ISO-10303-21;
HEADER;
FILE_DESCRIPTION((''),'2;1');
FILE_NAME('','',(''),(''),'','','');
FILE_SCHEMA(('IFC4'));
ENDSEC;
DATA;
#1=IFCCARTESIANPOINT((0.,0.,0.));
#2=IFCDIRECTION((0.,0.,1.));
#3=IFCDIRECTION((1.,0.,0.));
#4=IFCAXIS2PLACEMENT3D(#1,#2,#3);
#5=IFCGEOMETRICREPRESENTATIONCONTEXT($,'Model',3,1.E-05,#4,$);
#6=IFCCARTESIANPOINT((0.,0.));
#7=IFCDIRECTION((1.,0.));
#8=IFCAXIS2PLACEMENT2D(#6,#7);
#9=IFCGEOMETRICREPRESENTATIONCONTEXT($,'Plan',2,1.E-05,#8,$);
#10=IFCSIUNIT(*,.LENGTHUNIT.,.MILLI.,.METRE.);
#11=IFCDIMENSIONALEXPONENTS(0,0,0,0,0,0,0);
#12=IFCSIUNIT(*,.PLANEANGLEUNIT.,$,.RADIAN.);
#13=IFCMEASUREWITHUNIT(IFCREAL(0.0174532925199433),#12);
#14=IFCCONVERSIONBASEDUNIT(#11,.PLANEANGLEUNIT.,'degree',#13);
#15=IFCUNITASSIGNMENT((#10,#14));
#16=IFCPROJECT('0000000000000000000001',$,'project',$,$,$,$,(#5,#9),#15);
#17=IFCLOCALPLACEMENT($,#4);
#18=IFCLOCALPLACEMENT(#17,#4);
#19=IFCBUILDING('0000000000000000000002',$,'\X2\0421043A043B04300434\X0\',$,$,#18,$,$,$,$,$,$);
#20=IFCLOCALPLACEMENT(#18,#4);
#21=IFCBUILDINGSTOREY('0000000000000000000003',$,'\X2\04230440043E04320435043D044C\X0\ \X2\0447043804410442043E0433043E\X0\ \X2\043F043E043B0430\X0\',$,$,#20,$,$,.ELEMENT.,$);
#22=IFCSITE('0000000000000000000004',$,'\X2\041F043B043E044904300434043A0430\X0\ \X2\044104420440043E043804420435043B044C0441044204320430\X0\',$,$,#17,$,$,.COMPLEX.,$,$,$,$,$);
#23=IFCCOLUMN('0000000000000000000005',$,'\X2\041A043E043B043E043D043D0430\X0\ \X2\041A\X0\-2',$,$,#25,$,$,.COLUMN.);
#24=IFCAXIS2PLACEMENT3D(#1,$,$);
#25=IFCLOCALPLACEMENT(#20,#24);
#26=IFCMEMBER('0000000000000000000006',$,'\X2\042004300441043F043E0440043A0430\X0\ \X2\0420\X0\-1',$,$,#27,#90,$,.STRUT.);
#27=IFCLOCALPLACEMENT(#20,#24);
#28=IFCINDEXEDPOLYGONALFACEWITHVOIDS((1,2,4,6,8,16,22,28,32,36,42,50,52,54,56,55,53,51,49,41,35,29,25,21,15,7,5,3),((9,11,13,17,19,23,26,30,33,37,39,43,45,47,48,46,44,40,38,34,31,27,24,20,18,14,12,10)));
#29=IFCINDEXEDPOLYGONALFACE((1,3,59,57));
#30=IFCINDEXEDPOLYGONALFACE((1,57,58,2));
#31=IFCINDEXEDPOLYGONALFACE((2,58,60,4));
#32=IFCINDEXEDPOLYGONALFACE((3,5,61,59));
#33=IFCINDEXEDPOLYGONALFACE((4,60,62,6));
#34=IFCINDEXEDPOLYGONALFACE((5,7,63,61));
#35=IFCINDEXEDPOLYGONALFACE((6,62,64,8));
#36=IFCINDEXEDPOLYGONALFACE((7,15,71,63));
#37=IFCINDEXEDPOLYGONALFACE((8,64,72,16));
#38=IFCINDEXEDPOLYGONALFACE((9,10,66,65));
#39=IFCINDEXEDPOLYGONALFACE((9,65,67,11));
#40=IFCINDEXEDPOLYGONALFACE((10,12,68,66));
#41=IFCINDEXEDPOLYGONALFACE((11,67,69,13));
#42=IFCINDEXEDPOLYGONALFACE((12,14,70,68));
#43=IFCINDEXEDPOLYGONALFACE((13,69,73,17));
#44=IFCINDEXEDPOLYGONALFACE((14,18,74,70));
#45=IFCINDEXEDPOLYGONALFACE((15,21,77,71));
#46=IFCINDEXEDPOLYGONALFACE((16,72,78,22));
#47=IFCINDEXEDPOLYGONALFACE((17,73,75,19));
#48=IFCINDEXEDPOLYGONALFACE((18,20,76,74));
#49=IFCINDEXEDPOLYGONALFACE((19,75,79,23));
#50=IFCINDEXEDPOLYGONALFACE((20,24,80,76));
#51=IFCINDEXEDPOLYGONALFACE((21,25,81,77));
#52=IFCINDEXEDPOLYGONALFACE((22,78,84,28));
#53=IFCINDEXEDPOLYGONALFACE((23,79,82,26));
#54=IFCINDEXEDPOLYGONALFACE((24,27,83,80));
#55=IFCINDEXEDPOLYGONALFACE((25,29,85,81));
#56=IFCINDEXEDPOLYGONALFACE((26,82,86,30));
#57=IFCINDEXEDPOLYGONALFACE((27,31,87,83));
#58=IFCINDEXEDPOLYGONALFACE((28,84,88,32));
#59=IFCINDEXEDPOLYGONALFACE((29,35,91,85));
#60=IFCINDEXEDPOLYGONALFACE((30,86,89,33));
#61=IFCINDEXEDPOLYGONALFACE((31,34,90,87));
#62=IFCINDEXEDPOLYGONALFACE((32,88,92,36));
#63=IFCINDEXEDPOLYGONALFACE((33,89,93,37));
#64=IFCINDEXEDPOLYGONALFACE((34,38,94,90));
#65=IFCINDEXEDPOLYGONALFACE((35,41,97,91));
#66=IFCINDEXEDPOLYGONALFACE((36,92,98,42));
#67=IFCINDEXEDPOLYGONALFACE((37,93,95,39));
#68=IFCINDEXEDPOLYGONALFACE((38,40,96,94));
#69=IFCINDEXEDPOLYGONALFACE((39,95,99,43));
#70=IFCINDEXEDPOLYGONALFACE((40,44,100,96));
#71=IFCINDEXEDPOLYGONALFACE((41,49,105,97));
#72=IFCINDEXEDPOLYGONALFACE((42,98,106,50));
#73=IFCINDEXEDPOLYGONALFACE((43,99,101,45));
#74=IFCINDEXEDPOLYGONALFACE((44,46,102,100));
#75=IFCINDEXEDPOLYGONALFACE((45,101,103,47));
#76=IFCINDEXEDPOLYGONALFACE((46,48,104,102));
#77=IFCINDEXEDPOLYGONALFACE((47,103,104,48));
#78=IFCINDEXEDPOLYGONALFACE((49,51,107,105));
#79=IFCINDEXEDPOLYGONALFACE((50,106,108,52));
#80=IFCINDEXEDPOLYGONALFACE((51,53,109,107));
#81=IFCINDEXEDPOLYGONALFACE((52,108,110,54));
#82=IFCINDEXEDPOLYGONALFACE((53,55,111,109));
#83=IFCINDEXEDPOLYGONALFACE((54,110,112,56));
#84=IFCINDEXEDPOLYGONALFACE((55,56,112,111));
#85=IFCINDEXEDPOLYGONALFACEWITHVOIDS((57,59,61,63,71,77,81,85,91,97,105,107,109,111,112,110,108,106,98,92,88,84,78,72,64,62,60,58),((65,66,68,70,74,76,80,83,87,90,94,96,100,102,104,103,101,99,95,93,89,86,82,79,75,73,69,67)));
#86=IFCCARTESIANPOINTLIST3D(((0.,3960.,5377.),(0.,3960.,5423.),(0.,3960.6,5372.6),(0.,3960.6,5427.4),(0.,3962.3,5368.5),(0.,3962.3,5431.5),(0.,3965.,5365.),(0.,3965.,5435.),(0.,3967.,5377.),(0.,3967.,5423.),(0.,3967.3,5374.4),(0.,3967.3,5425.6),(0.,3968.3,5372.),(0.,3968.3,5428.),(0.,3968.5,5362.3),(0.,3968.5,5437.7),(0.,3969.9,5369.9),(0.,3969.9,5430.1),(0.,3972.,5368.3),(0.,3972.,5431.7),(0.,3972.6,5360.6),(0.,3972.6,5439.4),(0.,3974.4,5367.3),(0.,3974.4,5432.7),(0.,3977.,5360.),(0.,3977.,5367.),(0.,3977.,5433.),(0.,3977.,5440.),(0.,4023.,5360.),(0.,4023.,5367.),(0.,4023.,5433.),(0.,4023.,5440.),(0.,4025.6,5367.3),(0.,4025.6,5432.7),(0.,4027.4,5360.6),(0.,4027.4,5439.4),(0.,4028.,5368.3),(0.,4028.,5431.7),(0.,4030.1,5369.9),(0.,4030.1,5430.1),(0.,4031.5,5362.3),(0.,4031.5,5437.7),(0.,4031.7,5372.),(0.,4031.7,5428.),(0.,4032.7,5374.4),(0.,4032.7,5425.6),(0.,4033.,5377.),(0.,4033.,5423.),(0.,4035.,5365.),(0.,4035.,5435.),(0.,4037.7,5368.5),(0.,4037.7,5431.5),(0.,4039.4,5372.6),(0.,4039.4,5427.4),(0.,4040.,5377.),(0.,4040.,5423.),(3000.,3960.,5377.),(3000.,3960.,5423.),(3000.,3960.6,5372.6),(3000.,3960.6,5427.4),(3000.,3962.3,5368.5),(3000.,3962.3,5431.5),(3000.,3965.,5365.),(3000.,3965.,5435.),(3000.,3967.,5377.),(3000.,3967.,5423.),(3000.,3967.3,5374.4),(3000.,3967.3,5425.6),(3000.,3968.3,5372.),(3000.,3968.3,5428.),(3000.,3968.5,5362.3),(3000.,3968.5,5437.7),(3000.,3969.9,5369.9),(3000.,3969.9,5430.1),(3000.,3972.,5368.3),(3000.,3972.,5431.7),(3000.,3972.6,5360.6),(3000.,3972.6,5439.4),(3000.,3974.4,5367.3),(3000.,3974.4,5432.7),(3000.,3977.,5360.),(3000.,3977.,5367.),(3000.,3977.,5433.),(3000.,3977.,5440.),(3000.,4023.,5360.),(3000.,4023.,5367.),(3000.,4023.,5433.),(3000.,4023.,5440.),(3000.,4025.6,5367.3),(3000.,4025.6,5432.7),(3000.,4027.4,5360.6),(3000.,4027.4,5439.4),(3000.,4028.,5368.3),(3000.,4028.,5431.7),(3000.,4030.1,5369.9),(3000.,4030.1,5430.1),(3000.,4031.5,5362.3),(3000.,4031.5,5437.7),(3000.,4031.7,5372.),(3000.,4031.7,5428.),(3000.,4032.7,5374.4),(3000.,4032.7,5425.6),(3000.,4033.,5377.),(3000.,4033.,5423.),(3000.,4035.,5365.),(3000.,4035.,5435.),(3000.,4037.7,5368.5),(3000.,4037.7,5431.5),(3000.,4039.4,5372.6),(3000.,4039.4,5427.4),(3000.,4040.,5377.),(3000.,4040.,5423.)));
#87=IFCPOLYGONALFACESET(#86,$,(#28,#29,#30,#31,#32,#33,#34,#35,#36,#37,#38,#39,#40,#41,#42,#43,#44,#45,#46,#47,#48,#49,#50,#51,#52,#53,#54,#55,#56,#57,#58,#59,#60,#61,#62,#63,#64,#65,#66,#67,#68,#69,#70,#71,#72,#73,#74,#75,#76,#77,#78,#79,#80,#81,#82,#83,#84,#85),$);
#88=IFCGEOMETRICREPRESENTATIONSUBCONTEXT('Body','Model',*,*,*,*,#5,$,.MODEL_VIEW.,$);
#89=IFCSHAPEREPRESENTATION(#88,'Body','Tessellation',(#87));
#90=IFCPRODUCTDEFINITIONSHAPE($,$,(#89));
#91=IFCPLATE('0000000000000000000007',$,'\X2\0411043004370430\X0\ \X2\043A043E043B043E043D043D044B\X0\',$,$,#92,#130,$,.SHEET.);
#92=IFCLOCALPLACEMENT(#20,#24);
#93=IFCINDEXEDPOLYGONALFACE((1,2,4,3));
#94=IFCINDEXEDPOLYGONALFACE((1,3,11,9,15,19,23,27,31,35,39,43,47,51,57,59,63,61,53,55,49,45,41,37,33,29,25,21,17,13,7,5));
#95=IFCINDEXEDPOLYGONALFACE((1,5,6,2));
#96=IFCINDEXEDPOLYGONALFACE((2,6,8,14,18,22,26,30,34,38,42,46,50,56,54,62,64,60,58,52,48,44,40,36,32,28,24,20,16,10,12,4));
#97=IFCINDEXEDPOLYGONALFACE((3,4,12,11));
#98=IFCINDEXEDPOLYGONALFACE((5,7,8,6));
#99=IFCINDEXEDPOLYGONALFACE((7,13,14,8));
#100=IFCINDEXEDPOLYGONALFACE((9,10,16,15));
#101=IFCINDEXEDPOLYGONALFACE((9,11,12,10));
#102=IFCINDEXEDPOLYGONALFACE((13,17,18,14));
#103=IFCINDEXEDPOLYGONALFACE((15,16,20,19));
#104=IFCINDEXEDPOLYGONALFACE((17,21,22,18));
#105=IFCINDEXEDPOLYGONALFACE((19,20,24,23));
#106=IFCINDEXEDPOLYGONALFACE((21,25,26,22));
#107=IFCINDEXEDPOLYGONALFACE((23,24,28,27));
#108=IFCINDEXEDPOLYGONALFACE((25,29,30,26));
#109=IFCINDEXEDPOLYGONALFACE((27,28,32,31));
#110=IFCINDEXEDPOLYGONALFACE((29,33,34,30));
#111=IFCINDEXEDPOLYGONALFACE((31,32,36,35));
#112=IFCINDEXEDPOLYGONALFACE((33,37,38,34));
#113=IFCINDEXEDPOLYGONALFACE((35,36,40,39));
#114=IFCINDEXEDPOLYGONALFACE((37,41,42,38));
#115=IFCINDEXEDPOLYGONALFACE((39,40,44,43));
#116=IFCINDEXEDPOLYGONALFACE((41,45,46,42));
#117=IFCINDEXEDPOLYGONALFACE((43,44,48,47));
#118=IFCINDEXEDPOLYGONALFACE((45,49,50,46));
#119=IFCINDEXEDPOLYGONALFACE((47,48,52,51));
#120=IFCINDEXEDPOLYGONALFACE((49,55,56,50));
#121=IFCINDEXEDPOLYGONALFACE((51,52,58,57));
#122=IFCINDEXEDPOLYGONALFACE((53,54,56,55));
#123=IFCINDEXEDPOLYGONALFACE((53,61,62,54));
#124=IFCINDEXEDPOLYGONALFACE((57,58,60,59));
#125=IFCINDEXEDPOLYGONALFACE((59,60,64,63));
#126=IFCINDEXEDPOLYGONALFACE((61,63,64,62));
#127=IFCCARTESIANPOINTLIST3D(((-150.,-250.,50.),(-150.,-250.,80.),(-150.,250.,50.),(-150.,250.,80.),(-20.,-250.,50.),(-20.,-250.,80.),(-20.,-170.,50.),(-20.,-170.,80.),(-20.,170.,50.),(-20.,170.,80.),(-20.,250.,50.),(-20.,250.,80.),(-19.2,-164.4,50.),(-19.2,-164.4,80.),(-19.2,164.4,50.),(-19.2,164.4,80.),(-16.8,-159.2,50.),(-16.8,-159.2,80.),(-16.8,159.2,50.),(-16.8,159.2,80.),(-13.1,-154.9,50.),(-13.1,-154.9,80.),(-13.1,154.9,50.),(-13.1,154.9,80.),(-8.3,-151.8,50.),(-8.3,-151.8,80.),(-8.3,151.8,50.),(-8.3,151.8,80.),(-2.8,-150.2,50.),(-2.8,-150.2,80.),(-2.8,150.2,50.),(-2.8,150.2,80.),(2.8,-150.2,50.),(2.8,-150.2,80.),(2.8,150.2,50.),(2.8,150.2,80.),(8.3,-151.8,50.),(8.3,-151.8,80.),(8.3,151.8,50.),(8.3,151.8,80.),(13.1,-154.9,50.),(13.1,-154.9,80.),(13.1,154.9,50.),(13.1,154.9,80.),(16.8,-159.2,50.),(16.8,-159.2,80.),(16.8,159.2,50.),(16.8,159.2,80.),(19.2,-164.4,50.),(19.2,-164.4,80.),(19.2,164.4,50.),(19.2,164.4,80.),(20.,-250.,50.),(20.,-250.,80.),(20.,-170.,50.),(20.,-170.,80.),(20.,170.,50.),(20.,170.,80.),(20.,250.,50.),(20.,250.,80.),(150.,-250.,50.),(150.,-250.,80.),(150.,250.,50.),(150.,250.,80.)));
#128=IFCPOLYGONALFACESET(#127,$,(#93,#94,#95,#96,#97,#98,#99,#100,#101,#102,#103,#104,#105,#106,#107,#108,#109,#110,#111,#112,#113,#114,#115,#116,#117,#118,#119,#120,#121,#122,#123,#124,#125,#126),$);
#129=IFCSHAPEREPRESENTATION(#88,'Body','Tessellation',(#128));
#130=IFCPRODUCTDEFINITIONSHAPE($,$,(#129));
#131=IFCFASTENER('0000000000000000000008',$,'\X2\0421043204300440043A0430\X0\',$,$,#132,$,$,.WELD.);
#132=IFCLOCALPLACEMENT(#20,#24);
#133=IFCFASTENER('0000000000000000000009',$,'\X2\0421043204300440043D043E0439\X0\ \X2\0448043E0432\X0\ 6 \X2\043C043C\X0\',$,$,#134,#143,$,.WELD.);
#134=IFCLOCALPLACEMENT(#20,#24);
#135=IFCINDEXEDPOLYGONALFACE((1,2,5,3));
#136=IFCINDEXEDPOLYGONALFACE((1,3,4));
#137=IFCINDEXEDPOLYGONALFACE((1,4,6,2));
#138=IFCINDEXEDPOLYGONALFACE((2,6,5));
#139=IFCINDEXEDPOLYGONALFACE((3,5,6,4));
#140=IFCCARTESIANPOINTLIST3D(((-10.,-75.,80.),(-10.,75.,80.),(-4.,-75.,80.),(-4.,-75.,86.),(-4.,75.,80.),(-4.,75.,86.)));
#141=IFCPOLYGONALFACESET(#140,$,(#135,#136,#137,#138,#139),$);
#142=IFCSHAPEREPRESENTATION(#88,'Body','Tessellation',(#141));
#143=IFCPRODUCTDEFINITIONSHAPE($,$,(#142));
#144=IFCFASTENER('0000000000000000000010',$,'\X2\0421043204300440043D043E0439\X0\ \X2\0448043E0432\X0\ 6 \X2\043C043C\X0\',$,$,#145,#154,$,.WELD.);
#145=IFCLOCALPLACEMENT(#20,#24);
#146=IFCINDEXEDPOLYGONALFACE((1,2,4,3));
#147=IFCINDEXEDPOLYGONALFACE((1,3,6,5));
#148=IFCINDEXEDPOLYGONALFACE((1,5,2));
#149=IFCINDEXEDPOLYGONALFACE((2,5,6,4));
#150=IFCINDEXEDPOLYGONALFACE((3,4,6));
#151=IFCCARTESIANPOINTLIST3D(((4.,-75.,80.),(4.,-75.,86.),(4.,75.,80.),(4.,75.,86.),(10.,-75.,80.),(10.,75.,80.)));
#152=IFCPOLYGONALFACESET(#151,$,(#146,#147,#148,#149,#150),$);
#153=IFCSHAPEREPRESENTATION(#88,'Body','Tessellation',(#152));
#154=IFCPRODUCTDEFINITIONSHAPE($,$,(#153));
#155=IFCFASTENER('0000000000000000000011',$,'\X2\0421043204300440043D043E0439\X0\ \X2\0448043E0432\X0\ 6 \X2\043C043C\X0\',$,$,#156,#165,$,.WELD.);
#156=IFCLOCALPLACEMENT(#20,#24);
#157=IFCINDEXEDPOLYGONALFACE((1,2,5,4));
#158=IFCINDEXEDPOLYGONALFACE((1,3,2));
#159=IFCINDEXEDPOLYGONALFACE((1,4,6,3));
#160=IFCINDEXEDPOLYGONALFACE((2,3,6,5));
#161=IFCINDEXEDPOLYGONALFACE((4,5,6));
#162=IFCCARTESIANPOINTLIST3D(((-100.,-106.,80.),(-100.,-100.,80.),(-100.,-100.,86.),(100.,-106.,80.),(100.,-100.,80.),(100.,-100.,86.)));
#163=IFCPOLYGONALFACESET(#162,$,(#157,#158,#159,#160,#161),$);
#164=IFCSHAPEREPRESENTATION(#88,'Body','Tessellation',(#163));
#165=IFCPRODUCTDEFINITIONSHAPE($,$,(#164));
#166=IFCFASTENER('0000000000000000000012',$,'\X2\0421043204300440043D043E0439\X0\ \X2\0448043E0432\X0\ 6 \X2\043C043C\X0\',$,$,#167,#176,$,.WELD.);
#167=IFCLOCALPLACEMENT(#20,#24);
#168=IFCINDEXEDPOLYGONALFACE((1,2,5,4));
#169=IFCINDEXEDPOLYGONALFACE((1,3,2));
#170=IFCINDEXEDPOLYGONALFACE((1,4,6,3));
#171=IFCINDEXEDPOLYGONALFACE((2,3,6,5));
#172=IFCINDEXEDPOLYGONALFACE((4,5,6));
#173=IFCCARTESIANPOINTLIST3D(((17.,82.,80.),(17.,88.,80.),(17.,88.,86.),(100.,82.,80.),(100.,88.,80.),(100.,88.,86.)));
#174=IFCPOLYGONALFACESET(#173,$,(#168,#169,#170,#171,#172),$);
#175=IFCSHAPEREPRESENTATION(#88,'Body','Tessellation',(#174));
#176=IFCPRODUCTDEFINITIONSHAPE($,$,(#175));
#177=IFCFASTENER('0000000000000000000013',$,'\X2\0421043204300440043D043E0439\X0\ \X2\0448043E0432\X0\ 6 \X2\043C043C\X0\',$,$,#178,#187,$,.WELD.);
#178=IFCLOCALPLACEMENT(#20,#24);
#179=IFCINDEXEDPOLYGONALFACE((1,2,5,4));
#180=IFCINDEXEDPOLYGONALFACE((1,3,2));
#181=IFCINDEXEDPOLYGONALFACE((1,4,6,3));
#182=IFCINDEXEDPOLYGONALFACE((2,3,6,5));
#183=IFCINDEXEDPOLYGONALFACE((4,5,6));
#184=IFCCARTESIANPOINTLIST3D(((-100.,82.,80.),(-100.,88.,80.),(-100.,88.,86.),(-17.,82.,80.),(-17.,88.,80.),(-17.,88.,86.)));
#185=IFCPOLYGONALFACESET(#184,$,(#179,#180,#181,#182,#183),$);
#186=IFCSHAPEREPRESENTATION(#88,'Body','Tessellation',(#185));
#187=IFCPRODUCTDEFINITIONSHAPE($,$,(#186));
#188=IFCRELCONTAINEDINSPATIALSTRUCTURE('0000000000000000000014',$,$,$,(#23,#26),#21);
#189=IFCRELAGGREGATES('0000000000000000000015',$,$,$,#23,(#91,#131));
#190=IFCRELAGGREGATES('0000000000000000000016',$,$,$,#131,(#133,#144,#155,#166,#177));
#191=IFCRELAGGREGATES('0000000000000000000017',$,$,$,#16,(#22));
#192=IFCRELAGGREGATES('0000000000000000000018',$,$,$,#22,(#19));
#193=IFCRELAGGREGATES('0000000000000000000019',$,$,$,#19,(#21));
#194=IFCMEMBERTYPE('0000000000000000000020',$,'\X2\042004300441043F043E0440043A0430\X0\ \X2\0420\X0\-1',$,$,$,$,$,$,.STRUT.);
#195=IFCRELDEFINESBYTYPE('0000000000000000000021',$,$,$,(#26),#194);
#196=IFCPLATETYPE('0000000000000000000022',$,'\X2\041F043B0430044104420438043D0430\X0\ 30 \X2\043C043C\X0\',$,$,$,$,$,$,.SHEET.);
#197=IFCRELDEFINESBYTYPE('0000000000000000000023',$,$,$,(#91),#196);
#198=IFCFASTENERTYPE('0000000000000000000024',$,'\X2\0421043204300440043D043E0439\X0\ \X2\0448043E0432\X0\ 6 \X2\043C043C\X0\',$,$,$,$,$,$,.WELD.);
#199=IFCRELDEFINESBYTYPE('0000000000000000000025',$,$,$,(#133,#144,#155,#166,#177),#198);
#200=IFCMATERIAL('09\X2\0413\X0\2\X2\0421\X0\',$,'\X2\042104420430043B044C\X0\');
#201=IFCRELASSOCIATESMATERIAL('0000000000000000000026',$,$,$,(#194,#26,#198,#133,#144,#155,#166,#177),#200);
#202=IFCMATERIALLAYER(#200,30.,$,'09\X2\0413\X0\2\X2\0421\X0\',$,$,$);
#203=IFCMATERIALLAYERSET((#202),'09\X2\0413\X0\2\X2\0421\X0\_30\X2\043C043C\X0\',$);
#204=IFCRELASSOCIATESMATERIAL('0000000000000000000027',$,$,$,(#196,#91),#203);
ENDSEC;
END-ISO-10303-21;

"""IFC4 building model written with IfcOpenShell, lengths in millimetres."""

from ifc_helpers import new_model, entity, si_unit, converted_unit, frame, origin_with_axes, origin_2d_with_axis, place, context, subcontext, project, spatial, line, arc, indexed_curve, hollow_rectangle, outline, extrude, material, layer, layer_set, layer_usage, material_profile, profile_set, profile_usage, type_object, element, aggregate, save


model = new_model("IFC4")

# Units and contexts
model_context = context("Model", 3, precision=1e-05, world=origin_with_axes())
plan_context = context("Plan", 2, precision=1e-05, world=origin_2d_with_axis())
body_context = subcontext(model_context, "Body", "Model", "MODEL_VIEW")
ifc_project = project(units=[si_unit("LENGTHUNIT", "METRE", prefix="MILLI"), converted_unit("PLANEANGLEUNIT", "degree", entity("IfcReal", 0.0174532925199433), si_unit("PLANEANGLEUNIT", "RADIAN"), dimensions=[0, 0, 0, 0, 0, 0, 0])], contexts=[model_context, plan_context])

# Site, building, storey
site_placement = place(None, origin_with_axes())
site = spatial("IfcSite", under=ifc_project, at=site_placement, Name="Площадка строительства", CompositionType="COMPLEX")
building_placement = place(site_placement, origin_with_axes())
building = spatial("IfcBuilding", under=site, at=building_placement, Name="Склад")
storey_placement = place(building_placement, origin_with_axes())
storey = spatial("IfcBuildingStorey", under=building, at=storey_placement, Name="Уровень чистого пола", CompositionType="ELEMENT")

# Column
placement_1 = place(storey_placement, origin_with_axes())
column_1 = element("IfcColumn", 1, at=placement_1, inside=storey, Name="Колонна К-2", PredefinedType="COLUMN")
placement_2 = place(placement_1, origin_with_axes())

# Member
ifc_material_1 = material(Name="09Г2С", Category="Сталь")
ifc_material_profile_1 = material_profile(ifc_material_1, hollow_rectangle(XDim=80.0, YDim=80.0, WallThickness=7.0, InnerFilletRadius=10.0, OuterFilletRadius=17.0))
ifc_profile_set_1 = profile_set([ifc_material_profile_1], Name="PK80x7_09G2S")
ifc_profile_usage_1 = profile_usage(ifc_profile_set_1, cardinal=5)
member_type_1 = type_object("IfcMemberType", Name="Распорка Р-1", PredefinedType="STRUT", material=ifc_profile_set_1)
for number, where, z_axis, x_axis, name in (
    (2, (0.0, 4000.0, 5400.0), (1.0, 0.0, 0.0), (0.0, 1.0, 0.0), "Распорка Р-1"),
):
    element("IfcMember", number, at=place(storey_placement, frame(where, z_axis=z_axis, x_axis=x_axis)), inside=storey, type_object=member_type_1, material=ifc_profile_usage_1, Name=name, PredefinedType="STRUT", context=body_context, shape_type="SweptSolid", body=[
        extrude(hollow_rectangle(XDim=80.0, YDim=80.0, WallThickness=7.0, InnerFilletRadius=10.0, OuterFilletRadius=17.0), origin_with_axes(), (0.0, 0.0, 1.0), 3000.0),
    ])

# Plate
ifc_layer = layer(ifc_material_1, 30.0, Name="09Г2С")
ifc_layer_set = layer_set([ifc_layer], Name="09Г2С_30мм")
ifc_layer_usage = layer_usage(ifc_layer_set, "AXIS3", "POSITIVE", 0.0)
plate_type = type_object("IfcPlateType", Name="Пластина 30 мм", PredefinedType="SHEET", material=ifc_layer_set)
plate_placement = place(placement_1, frame((0.0, 0.0, 50.0), z_axis=(0.0, 0.0, 1.0), x_axis=(1.0, 0.0, 0.0)))
plate = element("IfcPlate", 3, at=plate_placement, type_object=plate_type, material=ifc_layer_usage, Name="База колонны", PredefinedType="SHEET", context=body_context, shape_type="SweptSolid", body=[
    extrude(outline(indexed_curve([(-20.0, -170.0), (0.0, -150.0), (20.0, -170.0), (20.0, -250.0), (150.0, -250.0), (150.0, 250.0), (20.0, 250.0), (20.0, 170.0), (0.0, 150.0), (-20.0, 170.0), (-20.0, 250.0), (-150.0, 250.0), (-150.0, -250.0), (-20.0, -250.0)], segments=[line(11, 12), line(12, 13), line(13, 14), line(14, 1), arc(1, 2, 3), line(3, 4), line(4, 5), line(5, 6), line(6, 7), line(7, 8), arc(8, 9, 10), line(10, 11)], self_intersect=False)), None, (0.0, 0.0, 1.0), 30.0),
])

# Fasteners
fastener_1 = element("IfcFastener", 4, at=placement_2, Name="Сварка", PredefinedType="WELD")
aggregate(column_1, [plate, fastener_1])
ifc_material_profile_2 = material_profile(ifc_material_1, outline(indexed_curve([(0.0, 0.0), (6.0, 0.0), (0.0, 6.0)], segments=[line(2, 3), line(3, 1), line(1, 2)], self_intersect=False)))
ifc_profile_set_2 = profile_set([ifc_material_profile_2])
ifc_profile_usage_2 = profile_usage(ifc_profile_set_2, cardinal=5)
fastener_type = type_object("IfcFastenerType", Name="Сварной шов 6 мм", PredefinedType="WELD", material=ifc_profile_set_2)
fastener_2_placement = place(placement_2, frame((-4.0, -75.0, 80.0), z_axis=(0.0, 1.0, 0.0), x_axis=(-1.0, 0.0, 0.0)))
fastener_2 = element("IfcFastener", 5, at=fastener_2_placement, type_object=fastener_type, material=ifc_profile_usage_2, Name="Сварной шов 6 мм", PredefinedType="WELD", context=body_context, shape_type="SweptSolid", body=[
    extrude(outline(indexed_curve([(0.0, 0.0), (6.0, 0.0), (0.0, 6.0)], segments=[line(2, 3), line(3, 1), line(1, 2)], self_intersect=False)), origin_with_axes(), (0.0, 0.0, 1.0), 150.0),
])
fastener_3_placement = place(placement_2, frame((4.0, 75.0, 80.0), z_axis=(0.0, -1.0, 0.0), x_axis=(1.0, 0.0, 0.0)))
fastener_3 = element("IfcFastener", 6, at=fastener_3_placement, type_object=fastener_type, material=ifc_profile_usage_2, Name="Сварной шов 6 мм", PredefinedType="WELD", context=body_context, shape_type="SweptSolid", body=[
    extrude(outline(indexed_curve([(0.0, 0.0), (6.0, 0.0), (0.0, 6.0)], segments=[line(2, 3), line(3, 1), line(1, 2)], self_intersect=False)), origin_with_axes(), (0.0, 0.0, 1.0), 150.0),
])
fastener_4_placement = place(placement_2, frame((100.0, -100.0, 80.0), z_axis=(-1.0, 0.0, 0.0), x_axis=(0.0, -1.0, 0.0)))
fastener_4 = element("IfcFastener", 7, at=fastener_4_placement, type_object=fastener_type, material=ifc_profile_usage_2, Name="Сварной шов 6 мм", PredefinedType="WELD", context=body_context, shape_type="SweptSolid", body=[
    extrude(outline(indexed_curve([(0.0, 0.0), (6.0, 0.0), (0.0, 6.0)], segments=[line(2, 3), line(3, 1), line(1, 2)], self_intersect=False)), origin_with_axes(), (0.0, 0.0, 1.0), 200.0),
])
fastener_5_placement = place(placement_2, frame((100.0, 88.0, 80.0), z_axis=(-1.0, 0.0, 0.0), x_axis=(0.0, -1.0, 0.0)))
fastener_5 = element("IfcFastener", 8, at=fastener_5_placement, type_object=fastener_type, material=ifc_profile_usage_2, Name="Сварной шов 6 мм", PredefinedType="WELD", context=body_context, shape_type="SweptSolid", body=[
    extrude(outline(indexed_curve([(0.0, 0.0), (6.0, 0.0), (0.0, 6.0)], segments=[line(2, 3), line(3, 1), line(1, 2)], self_intersect=False)), origin_with_axes(), (0.0, 0.0, 1.0), 83.0),
])
fastener_6_placement = place(placement_2, frame((-17.0, 88.0, 80.0), z_axis=(-1.0, 0.0, 0.0), x_axis=(0.0, -1.0, 0.0)))
fastener_6 = element("IfcFastener", 9, at=fastener_6_placement, type_object=fastener_type, material=ifc_profile_usage_2, Name="Сварной шов 6 мм", PredefinedType="WELD", context=body_context, shape_type="SweptSolid", body=[
    extrude(outline(indexed_curve([(0.0, 0.0), (6.0, 0.0), (0.0, 6.0)], segments=[line(2, 3), line(3, 1), line(1, 2)], self_intersect=False)), origin_with_axes(), (0.0, 0.0, 1.0), 83.0),
])
aggregate(fastener_1, [fastener_2, fastener_3, fastener_4, fastener_5, fastener_6])

save(model, "model.ifc")
